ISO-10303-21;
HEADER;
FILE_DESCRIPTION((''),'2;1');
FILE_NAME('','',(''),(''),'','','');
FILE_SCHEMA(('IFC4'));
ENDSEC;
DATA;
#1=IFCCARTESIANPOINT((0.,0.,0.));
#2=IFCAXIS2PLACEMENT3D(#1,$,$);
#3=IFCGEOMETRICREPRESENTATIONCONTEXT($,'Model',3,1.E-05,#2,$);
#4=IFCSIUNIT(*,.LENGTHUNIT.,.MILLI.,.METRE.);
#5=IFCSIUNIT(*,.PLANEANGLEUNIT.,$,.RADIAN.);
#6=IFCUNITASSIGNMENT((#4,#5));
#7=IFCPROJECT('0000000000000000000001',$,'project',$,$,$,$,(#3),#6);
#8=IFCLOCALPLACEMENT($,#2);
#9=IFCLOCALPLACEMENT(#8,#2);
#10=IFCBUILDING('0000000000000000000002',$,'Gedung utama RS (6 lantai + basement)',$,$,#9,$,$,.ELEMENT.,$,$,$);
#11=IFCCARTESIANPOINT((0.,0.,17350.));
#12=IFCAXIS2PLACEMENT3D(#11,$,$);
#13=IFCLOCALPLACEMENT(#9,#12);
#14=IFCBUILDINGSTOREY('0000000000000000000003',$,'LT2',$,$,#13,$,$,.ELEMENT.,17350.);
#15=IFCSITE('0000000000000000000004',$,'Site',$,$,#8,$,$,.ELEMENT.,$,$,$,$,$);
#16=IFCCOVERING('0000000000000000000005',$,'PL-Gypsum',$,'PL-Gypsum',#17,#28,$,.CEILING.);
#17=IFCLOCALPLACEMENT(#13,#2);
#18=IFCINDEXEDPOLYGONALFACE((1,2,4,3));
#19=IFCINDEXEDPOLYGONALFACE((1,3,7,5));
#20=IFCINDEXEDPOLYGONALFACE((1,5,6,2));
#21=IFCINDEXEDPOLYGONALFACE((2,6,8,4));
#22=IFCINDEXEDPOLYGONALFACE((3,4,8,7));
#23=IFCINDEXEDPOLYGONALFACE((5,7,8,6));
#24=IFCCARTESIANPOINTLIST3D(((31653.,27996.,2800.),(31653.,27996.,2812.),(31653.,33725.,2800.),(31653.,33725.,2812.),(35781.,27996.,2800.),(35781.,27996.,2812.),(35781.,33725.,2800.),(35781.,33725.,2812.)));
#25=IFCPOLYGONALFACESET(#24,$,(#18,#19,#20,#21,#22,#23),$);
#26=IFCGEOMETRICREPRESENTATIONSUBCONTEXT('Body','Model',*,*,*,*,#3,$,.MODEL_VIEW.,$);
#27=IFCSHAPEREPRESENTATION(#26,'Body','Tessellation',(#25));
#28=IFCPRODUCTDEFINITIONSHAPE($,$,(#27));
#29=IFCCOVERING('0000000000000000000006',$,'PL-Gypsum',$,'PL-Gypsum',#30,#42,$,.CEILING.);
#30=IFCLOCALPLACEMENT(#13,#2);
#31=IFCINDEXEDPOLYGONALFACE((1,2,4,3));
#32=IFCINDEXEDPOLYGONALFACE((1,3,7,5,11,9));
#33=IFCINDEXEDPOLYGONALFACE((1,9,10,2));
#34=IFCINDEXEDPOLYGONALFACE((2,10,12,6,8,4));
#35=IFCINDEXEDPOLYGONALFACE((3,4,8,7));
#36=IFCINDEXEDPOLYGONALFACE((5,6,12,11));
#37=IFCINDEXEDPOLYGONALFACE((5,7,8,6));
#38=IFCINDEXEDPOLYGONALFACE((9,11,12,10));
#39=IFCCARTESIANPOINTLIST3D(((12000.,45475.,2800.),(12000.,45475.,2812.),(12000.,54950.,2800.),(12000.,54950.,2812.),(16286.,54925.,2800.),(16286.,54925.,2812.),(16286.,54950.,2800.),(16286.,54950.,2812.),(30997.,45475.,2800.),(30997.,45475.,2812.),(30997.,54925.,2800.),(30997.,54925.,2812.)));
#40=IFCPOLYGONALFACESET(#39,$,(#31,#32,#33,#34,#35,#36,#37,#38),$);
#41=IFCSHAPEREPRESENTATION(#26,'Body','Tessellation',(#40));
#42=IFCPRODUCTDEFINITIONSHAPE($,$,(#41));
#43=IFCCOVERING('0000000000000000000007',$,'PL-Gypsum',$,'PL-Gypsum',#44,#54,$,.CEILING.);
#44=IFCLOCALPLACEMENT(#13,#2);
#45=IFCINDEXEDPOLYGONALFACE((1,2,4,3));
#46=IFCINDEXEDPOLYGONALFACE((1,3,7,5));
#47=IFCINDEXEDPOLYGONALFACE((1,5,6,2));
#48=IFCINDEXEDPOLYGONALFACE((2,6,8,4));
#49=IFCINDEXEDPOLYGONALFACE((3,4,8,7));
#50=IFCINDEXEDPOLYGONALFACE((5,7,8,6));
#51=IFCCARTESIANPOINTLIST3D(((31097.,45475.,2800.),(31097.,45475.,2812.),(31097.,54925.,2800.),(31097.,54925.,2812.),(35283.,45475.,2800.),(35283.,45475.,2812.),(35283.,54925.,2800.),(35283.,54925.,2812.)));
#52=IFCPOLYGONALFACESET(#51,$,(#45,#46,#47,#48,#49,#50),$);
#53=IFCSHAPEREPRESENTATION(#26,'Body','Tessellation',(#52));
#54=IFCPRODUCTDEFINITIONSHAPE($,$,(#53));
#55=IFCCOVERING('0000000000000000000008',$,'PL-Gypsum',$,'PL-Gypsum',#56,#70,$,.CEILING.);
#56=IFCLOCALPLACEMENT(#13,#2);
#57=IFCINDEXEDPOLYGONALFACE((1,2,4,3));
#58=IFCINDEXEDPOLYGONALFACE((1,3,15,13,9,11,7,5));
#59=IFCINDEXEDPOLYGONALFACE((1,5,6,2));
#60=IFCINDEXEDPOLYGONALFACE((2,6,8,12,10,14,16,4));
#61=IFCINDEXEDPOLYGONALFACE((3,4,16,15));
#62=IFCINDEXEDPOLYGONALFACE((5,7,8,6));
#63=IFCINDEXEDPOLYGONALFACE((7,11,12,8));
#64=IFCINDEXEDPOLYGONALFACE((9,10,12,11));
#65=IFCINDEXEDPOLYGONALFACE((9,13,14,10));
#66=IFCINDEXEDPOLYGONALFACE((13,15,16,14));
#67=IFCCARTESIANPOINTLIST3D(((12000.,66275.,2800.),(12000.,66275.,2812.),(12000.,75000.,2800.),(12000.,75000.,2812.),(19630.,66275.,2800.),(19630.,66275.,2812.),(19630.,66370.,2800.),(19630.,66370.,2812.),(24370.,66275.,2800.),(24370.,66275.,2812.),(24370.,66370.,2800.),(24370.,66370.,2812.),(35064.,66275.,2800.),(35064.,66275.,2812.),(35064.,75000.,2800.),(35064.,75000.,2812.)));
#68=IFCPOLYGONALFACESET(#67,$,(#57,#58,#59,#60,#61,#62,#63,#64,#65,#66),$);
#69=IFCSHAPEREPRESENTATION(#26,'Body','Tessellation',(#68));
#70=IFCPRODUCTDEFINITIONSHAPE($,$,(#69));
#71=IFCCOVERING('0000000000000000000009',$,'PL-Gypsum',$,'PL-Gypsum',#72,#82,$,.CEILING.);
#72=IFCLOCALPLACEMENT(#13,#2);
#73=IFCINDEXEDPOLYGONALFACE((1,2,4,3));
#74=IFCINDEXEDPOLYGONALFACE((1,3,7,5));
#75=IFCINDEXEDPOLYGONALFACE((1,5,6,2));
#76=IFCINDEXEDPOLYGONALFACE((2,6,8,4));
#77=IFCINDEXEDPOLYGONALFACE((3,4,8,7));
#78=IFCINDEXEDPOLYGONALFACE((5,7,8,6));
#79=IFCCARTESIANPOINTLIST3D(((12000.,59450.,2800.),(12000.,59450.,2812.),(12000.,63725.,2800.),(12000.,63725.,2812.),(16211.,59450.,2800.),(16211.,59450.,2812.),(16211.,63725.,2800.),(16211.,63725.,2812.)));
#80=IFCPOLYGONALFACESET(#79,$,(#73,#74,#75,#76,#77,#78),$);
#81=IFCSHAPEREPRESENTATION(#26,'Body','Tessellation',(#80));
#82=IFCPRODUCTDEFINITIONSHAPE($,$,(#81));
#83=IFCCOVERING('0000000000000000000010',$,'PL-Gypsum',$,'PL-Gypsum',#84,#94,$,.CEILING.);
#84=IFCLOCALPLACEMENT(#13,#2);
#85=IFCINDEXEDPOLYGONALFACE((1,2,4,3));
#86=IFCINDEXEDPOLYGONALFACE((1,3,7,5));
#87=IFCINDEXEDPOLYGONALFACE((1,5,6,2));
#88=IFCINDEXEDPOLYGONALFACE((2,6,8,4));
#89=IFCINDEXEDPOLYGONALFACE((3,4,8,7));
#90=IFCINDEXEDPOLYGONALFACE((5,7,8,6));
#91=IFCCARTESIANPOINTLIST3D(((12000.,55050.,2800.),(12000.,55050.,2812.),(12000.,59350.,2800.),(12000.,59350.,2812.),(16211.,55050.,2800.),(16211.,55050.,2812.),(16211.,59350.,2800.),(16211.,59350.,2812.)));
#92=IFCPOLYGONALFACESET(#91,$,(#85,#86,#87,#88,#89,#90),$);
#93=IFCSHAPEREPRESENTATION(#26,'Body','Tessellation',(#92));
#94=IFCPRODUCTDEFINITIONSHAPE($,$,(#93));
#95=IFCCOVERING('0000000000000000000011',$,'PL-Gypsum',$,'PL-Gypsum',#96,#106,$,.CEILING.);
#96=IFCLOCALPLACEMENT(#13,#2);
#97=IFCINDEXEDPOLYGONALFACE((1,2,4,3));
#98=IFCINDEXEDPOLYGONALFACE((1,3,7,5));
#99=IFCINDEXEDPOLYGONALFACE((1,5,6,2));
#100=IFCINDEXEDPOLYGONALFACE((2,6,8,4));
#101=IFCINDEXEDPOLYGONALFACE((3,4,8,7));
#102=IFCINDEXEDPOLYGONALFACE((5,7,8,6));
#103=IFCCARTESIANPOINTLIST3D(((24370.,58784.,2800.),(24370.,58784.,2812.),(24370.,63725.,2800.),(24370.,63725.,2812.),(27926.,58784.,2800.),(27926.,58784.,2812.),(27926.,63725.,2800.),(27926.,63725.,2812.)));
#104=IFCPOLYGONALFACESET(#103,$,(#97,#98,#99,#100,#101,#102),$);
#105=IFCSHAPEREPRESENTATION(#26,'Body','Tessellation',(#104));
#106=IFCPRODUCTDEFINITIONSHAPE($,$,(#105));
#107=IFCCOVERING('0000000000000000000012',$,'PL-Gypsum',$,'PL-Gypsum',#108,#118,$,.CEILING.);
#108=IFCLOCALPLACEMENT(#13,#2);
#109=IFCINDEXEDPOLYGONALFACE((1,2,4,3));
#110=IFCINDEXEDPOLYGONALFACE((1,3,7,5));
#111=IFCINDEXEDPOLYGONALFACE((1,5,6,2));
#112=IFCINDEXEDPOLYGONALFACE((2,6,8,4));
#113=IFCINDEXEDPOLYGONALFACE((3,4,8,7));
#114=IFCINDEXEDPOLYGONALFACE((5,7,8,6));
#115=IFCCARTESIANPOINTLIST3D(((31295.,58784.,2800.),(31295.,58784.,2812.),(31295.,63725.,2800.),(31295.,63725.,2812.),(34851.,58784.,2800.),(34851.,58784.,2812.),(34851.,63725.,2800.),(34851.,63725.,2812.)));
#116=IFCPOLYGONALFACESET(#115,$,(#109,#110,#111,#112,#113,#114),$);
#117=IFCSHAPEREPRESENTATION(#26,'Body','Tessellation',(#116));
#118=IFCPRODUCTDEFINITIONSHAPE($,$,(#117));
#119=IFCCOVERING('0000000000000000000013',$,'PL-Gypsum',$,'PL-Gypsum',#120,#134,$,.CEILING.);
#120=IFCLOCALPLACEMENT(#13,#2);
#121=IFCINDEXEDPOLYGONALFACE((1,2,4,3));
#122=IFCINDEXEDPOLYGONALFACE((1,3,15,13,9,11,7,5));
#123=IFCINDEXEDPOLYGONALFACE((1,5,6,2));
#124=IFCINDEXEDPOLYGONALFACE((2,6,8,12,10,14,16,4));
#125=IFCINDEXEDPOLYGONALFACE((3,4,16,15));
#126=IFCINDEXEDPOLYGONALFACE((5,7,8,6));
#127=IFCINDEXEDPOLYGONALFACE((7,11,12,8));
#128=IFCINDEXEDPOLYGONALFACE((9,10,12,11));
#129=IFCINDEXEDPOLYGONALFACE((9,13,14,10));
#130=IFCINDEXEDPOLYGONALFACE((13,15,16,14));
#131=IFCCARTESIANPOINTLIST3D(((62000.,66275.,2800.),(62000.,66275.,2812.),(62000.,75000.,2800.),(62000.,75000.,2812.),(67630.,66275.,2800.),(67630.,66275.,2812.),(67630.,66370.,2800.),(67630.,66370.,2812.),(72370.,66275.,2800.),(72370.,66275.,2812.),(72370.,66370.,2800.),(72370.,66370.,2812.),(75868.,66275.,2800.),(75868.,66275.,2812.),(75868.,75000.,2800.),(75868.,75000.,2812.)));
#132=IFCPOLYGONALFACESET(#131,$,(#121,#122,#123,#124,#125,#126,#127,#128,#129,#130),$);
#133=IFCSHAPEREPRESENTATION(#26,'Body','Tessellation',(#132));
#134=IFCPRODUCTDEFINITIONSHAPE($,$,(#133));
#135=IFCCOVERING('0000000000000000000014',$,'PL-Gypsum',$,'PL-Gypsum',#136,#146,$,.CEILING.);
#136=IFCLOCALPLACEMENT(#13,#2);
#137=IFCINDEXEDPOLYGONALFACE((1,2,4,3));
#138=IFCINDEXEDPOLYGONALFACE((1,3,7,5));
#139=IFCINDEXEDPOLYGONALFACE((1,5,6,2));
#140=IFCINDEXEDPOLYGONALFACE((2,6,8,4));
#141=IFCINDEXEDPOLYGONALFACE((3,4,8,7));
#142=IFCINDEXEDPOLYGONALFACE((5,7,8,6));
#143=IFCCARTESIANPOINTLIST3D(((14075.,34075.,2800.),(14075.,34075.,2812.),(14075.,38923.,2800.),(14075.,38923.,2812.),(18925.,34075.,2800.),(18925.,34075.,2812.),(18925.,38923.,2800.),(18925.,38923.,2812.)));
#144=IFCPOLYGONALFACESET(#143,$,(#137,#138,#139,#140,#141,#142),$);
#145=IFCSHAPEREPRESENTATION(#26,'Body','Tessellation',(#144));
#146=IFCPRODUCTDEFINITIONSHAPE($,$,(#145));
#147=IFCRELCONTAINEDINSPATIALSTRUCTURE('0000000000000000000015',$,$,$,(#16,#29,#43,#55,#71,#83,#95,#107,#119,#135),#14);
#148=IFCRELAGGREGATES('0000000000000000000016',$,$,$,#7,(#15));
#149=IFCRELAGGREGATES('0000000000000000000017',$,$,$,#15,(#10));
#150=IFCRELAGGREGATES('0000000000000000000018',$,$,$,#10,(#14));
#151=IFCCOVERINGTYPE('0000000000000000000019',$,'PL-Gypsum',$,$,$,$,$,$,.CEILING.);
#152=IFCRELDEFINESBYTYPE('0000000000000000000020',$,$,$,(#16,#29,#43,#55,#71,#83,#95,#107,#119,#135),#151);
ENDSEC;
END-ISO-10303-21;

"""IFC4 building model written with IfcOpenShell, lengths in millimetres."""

from ifc_helpers import new_model, si_unit, frame, origin, place, context, subcontext, project, spatial, polyline, outline, extrude, type_object, element, save


model = new_model("IFC4")

# Units and contexts
model_context = context("Model", 3, precision=1e-05, world=origin())
body_context = subcontext(model_context, "Body", "Model", "MODEL_VIEW")
ifc_project = project(units=[si_unit("LENGTHUNIT", "METRE", prefix="MILLI"), si_unit("PLANEANGLEUNIT", "RADIAN")], contexts=[model_context])

# Site, building, storey
site_placement = place(None, origin())
site = spatial("IfcSite", under=ifc_project, at=site_placement, Name="Site", CompositionType="ELEMENT")
building_placement = place(site_placement, origin())
building = spatial("IfcBuilding", under=site, at=building_placement, Name="Gedung utama RS (6 lantai + basement)", CompositionType="ELEMENT")
storey_placement = place(building_placement, frame((0.0, 0.0, 17350.0)))
storey = spatial("IfcBuildingStorey", under=building, at=storey_placement, Name="LT2", CompositionType="ELEMENT", Elevation=17350.0)

# Coverings
covering_type = type_object("IfcCoveringType", Name="PL-Gypsum", PredefinedType="CEILING")
covering_1_placement = place(storey_placement, origin())
element("IfcCovering", 1, at=covering_1_placement, inside=storey, type_object=covering_type, Name="PL-Gypsum", ObjectType="PL-Gypsum", PredefinedType="CEILING", context=body_context, shape_type="SweptSolid", body=[
    extrude(outline(polyline([(31653.0, 27996.0), (35781.0, 27996.0), (35781.0, 33725.0), (31653.0, 33725.0), (31653.0, 27996.0)])), frame((0.0, 0.0, 2800.0)), (0.0, 0.0, 1.0), 12.0),
])
covering_2_placement = place(storey_placement, origin())
element("IfcCovering", 2, at=covering_2_placement, inside=storey, type_object=covering_type, Name="PL-Gypsum", ObjectType="PL-Gypsum", PredefinedType="CEILING", context=body_context, shape_type="SweptSolid", body=[
    extrude(outline(polyline([(12000.0, 45475.0), (30997.0, 45475.0), (30997.0, 54925.0), (16286.0, 54925.0), (16286.0, 54950.0), (12000.0, 54950.0), (12000.0, 45475.0)])), frame((0.0, 0.0, 2800.0)), (0.0, 0.0, 1.0), 12.0),
])
covering_3_placement = place(storey_placement, origin())
element("IfcCovering", 3, at=covering_3_placement, inside=storey, type_object=covering_type, Name="PL-Gypsum", ObjectType="PL-Gypsum", PredefinedType="CEILING", context=body_context, shape_type="SweptSolid", body=[
    extrude(outline(polyline([(31097.0, 45475.0), (35283.0, 45475.0), (35283.0, 54925.0), (31097.0, 54925.0), (31097.0, 45475.0)])), frame((0.0, 0.0, 2800.0)), (0.0, 0.0, 1.0), 12.0),
])
covering_4_placement = place(storey_placement, origin())
element("IfcCovering", 4, at=covering_4_placement, inside=storey, type_object=covering_type, Name="PL-Gypsum", ObjectType="PL-Gypsum", PredefinedType="CEILING", context=body_context, shape_type="SweptSolid", body=[
    extrude(outline(polyline([(12000.0, 66275.0), (19630.0, 66275.0), (19630.0, 66370.0), (24370.0, 66370.0), (24370.0, 66275.0), (35064.0, 66275.0), (35064.0, 75000.0), (12000.0, 75000.0), (12000.0, 66275.0)])), frame((0.0, 0.0, 2800.0)), (0.0, 0.0, 1.0), 12.0),
])
covering_5_placement = place(storey_placement, origin())
element("IfcCovering", 5, at=covering_5_placement, inside=storey, type_object=covering_type, Name="PL-Gypsum", ObjectType="PL-Gypsum", PredefinedType="CEILING", context=body_context, shape_type="SweptSolid", body=[
    extrude(outline(polyline([(12000.0, 59450.0), (16211.0, 59450.0), (16211.0, 63725.0), (12000.0, 63725.0), (12000.0, 59450.0)])), frame((0.0, 0.0, 2800.0)), (0.0, 0.0, 1.0), 12.0),
])
covering_6_placement = place(storey_placement, origin())
element("IfcCovering", 6, at=covering_6_placement, inside=storey, type_object=covering_type, Name="PL-Gypsum", ObjectType="PL-Gypsum", PredefinedType="CEILING", context=body_context, shape_type="SweptSolid", body=[
    extrude(outline(polyline([(12000.0, 55050.0), (16211.0, 55050.0), (16211.0, 59350.0), (12000.0, 59350.0), (12000.0, 55050.0)])), frame((0.0, 0.0, 2800.0)), (0.0, 0.0, 1.0), 12.0),
])
covering_7_placement = place(storey_placement, origin())
element("IfcCovering", 7, at=covering_7_placement, inside=storey, type_object=covering_type, Name="PL-Gypsum", ObjectType="PL-Gypsum", PredefinedType="CEILING", context=body_context, shape_type="SweptSolid", body=[
    extrude(outline(polyline([(24370.0, 58784.0), (27926.0, 58784.0), (27926.0, 63725.0), (24370.0, 63725.0), (24370.0, 58784.0)])), frame((0.0, 0.0, 2800.0)), (0.0, 0.0, 1.0), 12.0),
])
covering_8_placement = place(storey_placement, origin())
element("IfcCovering", 8, at=covering_8_placement, inside=storey, type_object=covering_type, Name="PL-Gypsum", ObjectType="PL-Gypsum", PredefinedType="CEILING", context=body_context, shape_type="SweptSolid", body=[
    extrude(outline(polyline([(31295.0, 58784.0), (34851.0, 58784.0), (34851.0, 63725.0), (31295.0, 63725.0), (31295.0, 58784.0)])), frame((0.0, 0.0, 2800.0)), (0.0, 0.0, 1.0), 12.0),
])
covering_9_placement = place(storey_placement, origin())
element("IfcCovering", 9, at=covering_9_placement, inside=storey, type_object=covering_type, Name="PL-Gypsum", ObjectType="PL-Gypsum", PredefinedType="CEILING", context=body_context, shape_type="SweptSolid", body=[
    extrude(outline(polyline([(62000.0, 66275.0), (67630.0, 66275.0), (67630.0, 66370.0), (72370.0, 66370.0), (72370.0, 66275.0), (75868.0, 66275.0), (75868.0, 75000.0), (62000.0, 75000.0), (62000.0, 66275.0)])), frame((0.0, 0.0, 2800.0)), (0.0, 0.0, 1.0), 12.0),
])
covering_10_placement = place(storey_placement, origin())
element("IfcCovering", 10, at=covering_10_placement, inside=storey, type_object=covering_type, Name="PL-Gypsum", ObjectType="PL-Gypsum", PredefinedType="CEILING", context=body_context, shape_type="SweptSolid", body=[
    extrude(outline(polyline([(14075.0, 34075.0), (18925.0, 34075.0), (18925.0, 38923.0), (14075.0, 38923.0), (14075.0, 34075.0)])), frame((0.0, 0.0, 2800.0)), (0.0, 0.0, 1.0), 12.0),
])

save(model, "model.ifc")
